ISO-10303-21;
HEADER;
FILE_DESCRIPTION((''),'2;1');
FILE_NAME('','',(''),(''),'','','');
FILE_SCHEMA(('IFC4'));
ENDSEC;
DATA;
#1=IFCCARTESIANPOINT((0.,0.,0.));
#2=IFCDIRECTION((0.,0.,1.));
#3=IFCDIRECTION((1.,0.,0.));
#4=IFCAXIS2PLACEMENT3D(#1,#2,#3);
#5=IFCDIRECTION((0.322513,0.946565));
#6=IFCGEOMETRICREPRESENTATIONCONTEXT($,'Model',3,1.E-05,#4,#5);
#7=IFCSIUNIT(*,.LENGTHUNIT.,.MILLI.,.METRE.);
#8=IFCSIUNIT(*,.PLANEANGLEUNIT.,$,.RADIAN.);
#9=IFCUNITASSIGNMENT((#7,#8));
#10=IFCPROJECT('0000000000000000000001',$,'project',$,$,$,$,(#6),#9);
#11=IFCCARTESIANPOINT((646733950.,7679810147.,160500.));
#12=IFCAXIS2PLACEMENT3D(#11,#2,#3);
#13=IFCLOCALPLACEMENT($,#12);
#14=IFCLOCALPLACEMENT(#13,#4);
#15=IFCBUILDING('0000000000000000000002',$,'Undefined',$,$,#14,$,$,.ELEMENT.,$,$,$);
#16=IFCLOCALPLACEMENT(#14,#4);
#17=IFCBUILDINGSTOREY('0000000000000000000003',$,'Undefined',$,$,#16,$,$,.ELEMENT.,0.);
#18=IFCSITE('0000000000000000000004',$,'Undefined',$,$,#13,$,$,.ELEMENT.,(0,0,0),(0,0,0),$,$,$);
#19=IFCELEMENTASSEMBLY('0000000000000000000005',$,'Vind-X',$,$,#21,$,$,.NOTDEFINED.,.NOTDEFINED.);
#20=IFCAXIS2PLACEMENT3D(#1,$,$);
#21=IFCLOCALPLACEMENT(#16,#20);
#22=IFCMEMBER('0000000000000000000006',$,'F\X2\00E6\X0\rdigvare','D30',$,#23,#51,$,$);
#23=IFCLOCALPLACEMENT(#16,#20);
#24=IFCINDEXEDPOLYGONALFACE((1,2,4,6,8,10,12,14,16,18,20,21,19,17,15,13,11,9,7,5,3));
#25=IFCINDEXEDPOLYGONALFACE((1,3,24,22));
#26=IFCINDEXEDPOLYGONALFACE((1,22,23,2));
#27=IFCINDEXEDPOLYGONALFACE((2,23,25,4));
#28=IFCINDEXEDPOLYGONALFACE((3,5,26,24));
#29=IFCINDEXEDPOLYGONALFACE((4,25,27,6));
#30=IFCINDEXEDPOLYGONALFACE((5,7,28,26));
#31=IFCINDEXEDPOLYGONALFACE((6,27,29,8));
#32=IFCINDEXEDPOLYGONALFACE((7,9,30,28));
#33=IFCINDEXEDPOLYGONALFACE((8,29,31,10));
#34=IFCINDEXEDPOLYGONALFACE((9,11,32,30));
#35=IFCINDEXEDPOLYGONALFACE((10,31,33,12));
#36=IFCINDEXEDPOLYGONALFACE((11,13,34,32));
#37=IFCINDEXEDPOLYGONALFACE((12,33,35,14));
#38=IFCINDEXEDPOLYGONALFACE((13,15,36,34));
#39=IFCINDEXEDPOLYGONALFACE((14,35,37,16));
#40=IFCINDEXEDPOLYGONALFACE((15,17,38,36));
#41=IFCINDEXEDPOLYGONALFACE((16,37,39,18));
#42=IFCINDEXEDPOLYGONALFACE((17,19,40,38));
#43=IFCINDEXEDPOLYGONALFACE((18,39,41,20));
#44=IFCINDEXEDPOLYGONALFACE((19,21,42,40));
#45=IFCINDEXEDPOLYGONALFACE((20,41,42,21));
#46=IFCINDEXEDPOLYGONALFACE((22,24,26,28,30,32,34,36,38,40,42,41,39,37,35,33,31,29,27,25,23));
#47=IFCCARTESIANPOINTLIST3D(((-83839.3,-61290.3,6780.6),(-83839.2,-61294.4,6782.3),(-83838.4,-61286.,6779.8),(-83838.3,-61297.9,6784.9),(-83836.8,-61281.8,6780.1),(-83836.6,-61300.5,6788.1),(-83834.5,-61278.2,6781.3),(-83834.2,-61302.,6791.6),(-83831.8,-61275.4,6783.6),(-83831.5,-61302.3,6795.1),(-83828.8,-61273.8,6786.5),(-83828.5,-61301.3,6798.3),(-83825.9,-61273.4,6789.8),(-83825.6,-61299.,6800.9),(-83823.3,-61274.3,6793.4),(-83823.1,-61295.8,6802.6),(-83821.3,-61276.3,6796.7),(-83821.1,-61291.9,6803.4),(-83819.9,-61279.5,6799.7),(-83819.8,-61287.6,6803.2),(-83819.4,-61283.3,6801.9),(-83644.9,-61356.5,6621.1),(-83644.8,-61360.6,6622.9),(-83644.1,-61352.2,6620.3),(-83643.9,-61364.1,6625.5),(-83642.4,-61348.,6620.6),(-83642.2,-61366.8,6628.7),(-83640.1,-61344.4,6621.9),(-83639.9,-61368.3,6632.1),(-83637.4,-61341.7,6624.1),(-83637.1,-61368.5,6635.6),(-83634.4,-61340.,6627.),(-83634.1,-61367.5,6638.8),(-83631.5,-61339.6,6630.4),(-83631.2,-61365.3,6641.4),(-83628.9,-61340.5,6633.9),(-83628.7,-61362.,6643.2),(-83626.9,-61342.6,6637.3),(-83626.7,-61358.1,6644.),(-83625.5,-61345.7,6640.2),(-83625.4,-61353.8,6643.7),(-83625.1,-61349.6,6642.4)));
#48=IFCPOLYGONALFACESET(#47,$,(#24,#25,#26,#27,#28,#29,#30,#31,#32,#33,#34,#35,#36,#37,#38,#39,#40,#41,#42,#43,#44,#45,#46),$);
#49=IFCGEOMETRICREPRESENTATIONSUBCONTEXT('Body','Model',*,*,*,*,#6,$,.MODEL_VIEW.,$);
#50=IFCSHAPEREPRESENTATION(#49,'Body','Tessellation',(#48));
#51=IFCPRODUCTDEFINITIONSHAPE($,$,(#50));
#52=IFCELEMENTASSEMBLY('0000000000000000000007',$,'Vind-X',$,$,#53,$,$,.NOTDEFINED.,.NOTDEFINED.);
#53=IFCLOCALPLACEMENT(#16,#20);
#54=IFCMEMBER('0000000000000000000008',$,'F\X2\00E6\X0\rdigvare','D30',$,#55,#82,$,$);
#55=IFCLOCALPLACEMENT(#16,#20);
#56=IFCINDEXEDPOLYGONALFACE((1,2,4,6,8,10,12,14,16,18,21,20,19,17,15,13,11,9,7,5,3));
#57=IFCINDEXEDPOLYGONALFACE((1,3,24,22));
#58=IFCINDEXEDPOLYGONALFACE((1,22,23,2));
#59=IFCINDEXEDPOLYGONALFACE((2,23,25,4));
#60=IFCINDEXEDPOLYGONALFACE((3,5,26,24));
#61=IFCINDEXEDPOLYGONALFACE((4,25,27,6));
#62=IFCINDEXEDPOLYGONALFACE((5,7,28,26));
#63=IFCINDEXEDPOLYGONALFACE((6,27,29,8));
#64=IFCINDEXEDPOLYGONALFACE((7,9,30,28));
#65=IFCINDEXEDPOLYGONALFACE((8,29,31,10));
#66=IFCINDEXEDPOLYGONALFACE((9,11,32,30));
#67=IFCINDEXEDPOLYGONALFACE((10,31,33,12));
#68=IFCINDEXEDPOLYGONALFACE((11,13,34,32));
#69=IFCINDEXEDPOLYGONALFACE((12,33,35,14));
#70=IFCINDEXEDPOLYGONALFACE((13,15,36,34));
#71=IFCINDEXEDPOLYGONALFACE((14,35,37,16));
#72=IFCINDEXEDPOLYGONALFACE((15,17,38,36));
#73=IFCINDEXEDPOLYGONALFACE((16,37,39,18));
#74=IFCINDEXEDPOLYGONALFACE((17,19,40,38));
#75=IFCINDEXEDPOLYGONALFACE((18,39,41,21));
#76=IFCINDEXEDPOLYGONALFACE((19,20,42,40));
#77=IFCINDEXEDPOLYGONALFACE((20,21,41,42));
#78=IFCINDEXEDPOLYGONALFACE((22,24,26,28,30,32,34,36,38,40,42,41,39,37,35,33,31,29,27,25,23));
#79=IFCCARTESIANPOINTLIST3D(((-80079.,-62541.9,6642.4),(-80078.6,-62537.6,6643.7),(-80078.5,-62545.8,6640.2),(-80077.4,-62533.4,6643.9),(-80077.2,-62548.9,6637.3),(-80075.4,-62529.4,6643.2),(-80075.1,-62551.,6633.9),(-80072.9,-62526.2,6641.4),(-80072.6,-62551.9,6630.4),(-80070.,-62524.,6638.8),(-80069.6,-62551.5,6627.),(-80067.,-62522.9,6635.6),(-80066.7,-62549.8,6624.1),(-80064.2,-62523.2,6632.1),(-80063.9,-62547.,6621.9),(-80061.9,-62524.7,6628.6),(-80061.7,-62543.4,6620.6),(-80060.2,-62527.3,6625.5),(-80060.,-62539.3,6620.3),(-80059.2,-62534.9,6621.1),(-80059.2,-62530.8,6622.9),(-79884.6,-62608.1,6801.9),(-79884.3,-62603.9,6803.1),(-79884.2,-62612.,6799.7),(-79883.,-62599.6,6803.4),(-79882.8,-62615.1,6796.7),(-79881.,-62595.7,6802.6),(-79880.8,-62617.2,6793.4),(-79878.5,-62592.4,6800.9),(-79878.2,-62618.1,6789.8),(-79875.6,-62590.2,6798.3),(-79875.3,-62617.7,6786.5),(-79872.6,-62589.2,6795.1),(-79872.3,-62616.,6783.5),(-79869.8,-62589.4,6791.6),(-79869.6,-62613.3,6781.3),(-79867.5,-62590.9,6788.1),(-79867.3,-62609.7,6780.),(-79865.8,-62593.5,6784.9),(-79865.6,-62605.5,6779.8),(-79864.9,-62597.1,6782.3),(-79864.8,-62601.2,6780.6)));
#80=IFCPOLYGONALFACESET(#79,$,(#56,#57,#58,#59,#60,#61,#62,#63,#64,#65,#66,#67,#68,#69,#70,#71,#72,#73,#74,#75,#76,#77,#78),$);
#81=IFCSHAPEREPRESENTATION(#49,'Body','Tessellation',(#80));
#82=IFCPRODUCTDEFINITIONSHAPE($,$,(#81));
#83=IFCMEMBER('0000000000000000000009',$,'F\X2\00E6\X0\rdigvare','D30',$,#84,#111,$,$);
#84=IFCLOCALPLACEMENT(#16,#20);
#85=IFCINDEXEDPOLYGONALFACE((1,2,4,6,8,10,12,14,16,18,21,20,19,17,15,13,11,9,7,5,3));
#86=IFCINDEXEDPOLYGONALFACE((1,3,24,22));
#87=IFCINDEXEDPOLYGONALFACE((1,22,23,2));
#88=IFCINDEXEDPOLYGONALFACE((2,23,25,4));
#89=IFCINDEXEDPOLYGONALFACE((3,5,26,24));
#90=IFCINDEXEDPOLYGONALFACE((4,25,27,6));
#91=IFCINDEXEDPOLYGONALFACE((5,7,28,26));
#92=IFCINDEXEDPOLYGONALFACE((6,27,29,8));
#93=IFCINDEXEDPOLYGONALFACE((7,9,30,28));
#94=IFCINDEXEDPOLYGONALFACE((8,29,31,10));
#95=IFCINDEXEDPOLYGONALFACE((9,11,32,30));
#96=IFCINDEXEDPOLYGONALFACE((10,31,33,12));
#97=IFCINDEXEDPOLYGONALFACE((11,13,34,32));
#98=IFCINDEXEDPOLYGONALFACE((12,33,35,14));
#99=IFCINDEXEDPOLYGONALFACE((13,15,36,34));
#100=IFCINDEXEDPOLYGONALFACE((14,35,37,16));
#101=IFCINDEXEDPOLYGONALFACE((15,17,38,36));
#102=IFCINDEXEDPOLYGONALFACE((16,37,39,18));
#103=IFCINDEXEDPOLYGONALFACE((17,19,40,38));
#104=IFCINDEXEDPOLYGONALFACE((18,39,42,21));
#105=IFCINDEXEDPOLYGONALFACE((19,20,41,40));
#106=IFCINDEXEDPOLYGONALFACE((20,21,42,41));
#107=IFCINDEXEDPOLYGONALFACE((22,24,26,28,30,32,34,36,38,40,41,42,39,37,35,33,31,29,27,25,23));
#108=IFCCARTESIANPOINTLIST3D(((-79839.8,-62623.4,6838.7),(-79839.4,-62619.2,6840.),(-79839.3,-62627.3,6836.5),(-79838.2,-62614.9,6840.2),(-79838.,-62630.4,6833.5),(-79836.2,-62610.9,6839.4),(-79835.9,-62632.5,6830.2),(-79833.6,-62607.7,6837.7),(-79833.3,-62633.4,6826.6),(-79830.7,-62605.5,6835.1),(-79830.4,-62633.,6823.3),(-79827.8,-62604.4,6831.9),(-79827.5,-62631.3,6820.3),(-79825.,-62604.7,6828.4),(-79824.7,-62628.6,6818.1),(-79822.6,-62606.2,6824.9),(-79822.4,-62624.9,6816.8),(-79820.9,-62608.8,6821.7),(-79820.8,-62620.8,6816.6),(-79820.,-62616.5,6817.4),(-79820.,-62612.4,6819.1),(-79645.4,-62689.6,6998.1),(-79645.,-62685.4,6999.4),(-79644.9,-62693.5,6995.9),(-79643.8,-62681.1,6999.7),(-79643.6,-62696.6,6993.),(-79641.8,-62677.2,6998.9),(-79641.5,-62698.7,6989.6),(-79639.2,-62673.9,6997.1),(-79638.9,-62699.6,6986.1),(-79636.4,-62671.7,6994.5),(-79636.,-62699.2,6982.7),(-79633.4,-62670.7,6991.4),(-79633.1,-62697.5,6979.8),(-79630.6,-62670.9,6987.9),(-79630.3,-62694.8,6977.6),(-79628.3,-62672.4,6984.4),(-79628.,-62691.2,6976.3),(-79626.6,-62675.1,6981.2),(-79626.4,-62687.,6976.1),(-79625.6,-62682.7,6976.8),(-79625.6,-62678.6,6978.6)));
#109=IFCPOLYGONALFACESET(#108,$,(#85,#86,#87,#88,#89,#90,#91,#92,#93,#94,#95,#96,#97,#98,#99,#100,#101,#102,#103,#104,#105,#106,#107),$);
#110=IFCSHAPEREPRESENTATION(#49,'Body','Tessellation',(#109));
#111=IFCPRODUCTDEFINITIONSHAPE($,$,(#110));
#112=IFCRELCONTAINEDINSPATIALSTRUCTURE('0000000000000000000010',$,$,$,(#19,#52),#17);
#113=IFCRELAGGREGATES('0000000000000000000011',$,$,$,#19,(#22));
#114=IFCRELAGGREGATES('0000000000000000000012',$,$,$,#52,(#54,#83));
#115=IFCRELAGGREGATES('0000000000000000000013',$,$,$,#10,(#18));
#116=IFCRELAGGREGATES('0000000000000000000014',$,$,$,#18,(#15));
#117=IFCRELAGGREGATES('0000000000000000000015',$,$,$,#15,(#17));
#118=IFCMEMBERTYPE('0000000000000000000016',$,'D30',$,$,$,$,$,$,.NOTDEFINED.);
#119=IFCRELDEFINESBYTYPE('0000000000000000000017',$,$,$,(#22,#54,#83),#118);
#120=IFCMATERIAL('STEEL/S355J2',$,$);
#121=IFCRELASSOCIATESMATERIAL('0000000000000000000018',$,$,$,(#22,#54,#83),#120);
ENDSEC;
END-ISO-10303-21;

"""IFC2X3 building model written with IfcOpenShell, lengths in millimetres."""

from ifc_helpers import new_model, si_unit, direction, frame, origin_with_axes, origin_2d_with_axis, place, context, subcontext, project, spatial, circle, extrude, material, type_object, element, aggregate, save


model = new_model("IFC2X3")

# Units and contexts
model_context = context("Model", 3, precision=1e-05, world=origin_with_axes(), true_north=direction((0.322513, 0.946565)))
body_context = subcontext(model_context, "Body", "Model", "MODEL_VIEW")
ifc_project = project(units=[si_unit("LENGTHUNIT", "METRE", prefix="MILLI"), si_unit("PLANEANGLEUNIT", "RADIAN")], contexts=[model_context])

# Site, building, storey
site_placement = place(None, frame((646733950.0, 7679810147.0, 160500.0), z_axis=(0.0, 0.0, 1.0), x_axis=(1.0, 0.0, 0.0)))
site = spatial("IfcSite", under=ifc_project, at=site_placement, Name="Undefined", CompositionType="ELEMENT", RefLatitude=(0, 0, 0), RefLongitude=(0, 0, 0))
building_placement = place(site_placement, origin_with_axes())
building = spatial("IfcBuilding", under=site, at=building_placement, Name="Undefined", CompositionType="ELEMENT")
storey_placement = place(building_placement, origin_with_axes())
storey = spatial("IfcBuildingStorey", under=building, at=storey_placement, Name="Undefined", CompositionType="ELEMENT", Elevation=0.0)

# Element assembly, member
assembly_1_placement = place(storey_placement, origin_with_axes())
assembly_1 = element("IfcElementAssembly", 1, at=assembly_1_placement, inside=storey, Name="Vind-X", AssemblyPlace="NOTDEFINED", PredefinedType="NOTDEFINED")
ifc_material_1 = material(Name="STEEL/S355J2")
member_type_1 = type_object("IfcMemberType", Name="D30", PredefinedType="NOTDEFINED")
member_1_placement = place(assembly_1_placement, frame((-83829.4, -61287.8, 6791.6), z_axis=(0.580541, -0.197802, 0.789839), x_axis=(0.747634, -0.254733, -0.613314)))
member_1 = element("IfcMember", 2, at=member_1_placement, type_object=member_type_1, material=ifc_material_1, Name="Færdigvare", Description="D30", context=body_context, shape_type="SweptSolid", body=[
    extrude(circle(Radius=15.0, at=origin_2d_with_axis()), frame((260.0, 0.0, 0.0), z_axis=(-1.0, 0.0, 0.0), x_axis=(0.0, -1.0, 0.0)), (0.0, 0.0, 1.0), 260.0),
])

# Element assembly, members
assembly_2_placement = place(storey_placement, origin_with_axes())
assembly_2 = element("IfcElementAssembly", 3, at=assembly_2_placement, inside=storey, Name="Vind-X", AssemblyPlace="NOTDEFINED", PredefinedType="NOTDEFINED")
member_2_placement = place(assembly_2_placement, frame((-79874.7, -62603.6, 6791.6), z_axis=(-0.580574, 0.197813, 0.789813), x_axis=(-0.747609, 0.254725, -0.613348)))
member_2 = element("IfcMember", 4, at=member_2_placement, type_object=member_type_1, material=ifc_material_1, Name="Færdigvare", Description="D30", context=body_context, shape_type="SweptSolid", body=[
    extrude(circle(Radius=15.0, at=origin_2d_with_axis()), frame((260.0, 0.0, 0.0), z_axis=(-1.0, 0.0, 0.0), x_axis=(0.0, -1.0, 0.0)), (0.0, 0.0, 1.0), 260.0),
])
member_3_placement = place(assembly_2_placement, frame((-79635.5, -62685.1, 6987.9), z_axis=(-0.580575, 0.197813, 0.789812), x_axis=(-0.747608, 0.254725, -0.613349)))
member_3 = element("IfcMember", 5, at=member_3_placement, type_object=member_type_1, material=ifc_material_1, Name="Færdigvare", Description="D30", context=body_context, shape_type="SweptSolid", body=[
    extrude(circle(Radius=15.0, at=origin_2d_with_axis()), frame((260.0, 0.0, 0.0), z_axis=(-1.0, 0.0, 0.0), x_axis=(0.0, -1.0, 0.0)), (0.0, 0.0, 1.0), 260.0),
])

aggregate(assembly_1, [member_1])

aggregate(assembly_2, [member_2, member_3])

save(model, "model.ifc")
